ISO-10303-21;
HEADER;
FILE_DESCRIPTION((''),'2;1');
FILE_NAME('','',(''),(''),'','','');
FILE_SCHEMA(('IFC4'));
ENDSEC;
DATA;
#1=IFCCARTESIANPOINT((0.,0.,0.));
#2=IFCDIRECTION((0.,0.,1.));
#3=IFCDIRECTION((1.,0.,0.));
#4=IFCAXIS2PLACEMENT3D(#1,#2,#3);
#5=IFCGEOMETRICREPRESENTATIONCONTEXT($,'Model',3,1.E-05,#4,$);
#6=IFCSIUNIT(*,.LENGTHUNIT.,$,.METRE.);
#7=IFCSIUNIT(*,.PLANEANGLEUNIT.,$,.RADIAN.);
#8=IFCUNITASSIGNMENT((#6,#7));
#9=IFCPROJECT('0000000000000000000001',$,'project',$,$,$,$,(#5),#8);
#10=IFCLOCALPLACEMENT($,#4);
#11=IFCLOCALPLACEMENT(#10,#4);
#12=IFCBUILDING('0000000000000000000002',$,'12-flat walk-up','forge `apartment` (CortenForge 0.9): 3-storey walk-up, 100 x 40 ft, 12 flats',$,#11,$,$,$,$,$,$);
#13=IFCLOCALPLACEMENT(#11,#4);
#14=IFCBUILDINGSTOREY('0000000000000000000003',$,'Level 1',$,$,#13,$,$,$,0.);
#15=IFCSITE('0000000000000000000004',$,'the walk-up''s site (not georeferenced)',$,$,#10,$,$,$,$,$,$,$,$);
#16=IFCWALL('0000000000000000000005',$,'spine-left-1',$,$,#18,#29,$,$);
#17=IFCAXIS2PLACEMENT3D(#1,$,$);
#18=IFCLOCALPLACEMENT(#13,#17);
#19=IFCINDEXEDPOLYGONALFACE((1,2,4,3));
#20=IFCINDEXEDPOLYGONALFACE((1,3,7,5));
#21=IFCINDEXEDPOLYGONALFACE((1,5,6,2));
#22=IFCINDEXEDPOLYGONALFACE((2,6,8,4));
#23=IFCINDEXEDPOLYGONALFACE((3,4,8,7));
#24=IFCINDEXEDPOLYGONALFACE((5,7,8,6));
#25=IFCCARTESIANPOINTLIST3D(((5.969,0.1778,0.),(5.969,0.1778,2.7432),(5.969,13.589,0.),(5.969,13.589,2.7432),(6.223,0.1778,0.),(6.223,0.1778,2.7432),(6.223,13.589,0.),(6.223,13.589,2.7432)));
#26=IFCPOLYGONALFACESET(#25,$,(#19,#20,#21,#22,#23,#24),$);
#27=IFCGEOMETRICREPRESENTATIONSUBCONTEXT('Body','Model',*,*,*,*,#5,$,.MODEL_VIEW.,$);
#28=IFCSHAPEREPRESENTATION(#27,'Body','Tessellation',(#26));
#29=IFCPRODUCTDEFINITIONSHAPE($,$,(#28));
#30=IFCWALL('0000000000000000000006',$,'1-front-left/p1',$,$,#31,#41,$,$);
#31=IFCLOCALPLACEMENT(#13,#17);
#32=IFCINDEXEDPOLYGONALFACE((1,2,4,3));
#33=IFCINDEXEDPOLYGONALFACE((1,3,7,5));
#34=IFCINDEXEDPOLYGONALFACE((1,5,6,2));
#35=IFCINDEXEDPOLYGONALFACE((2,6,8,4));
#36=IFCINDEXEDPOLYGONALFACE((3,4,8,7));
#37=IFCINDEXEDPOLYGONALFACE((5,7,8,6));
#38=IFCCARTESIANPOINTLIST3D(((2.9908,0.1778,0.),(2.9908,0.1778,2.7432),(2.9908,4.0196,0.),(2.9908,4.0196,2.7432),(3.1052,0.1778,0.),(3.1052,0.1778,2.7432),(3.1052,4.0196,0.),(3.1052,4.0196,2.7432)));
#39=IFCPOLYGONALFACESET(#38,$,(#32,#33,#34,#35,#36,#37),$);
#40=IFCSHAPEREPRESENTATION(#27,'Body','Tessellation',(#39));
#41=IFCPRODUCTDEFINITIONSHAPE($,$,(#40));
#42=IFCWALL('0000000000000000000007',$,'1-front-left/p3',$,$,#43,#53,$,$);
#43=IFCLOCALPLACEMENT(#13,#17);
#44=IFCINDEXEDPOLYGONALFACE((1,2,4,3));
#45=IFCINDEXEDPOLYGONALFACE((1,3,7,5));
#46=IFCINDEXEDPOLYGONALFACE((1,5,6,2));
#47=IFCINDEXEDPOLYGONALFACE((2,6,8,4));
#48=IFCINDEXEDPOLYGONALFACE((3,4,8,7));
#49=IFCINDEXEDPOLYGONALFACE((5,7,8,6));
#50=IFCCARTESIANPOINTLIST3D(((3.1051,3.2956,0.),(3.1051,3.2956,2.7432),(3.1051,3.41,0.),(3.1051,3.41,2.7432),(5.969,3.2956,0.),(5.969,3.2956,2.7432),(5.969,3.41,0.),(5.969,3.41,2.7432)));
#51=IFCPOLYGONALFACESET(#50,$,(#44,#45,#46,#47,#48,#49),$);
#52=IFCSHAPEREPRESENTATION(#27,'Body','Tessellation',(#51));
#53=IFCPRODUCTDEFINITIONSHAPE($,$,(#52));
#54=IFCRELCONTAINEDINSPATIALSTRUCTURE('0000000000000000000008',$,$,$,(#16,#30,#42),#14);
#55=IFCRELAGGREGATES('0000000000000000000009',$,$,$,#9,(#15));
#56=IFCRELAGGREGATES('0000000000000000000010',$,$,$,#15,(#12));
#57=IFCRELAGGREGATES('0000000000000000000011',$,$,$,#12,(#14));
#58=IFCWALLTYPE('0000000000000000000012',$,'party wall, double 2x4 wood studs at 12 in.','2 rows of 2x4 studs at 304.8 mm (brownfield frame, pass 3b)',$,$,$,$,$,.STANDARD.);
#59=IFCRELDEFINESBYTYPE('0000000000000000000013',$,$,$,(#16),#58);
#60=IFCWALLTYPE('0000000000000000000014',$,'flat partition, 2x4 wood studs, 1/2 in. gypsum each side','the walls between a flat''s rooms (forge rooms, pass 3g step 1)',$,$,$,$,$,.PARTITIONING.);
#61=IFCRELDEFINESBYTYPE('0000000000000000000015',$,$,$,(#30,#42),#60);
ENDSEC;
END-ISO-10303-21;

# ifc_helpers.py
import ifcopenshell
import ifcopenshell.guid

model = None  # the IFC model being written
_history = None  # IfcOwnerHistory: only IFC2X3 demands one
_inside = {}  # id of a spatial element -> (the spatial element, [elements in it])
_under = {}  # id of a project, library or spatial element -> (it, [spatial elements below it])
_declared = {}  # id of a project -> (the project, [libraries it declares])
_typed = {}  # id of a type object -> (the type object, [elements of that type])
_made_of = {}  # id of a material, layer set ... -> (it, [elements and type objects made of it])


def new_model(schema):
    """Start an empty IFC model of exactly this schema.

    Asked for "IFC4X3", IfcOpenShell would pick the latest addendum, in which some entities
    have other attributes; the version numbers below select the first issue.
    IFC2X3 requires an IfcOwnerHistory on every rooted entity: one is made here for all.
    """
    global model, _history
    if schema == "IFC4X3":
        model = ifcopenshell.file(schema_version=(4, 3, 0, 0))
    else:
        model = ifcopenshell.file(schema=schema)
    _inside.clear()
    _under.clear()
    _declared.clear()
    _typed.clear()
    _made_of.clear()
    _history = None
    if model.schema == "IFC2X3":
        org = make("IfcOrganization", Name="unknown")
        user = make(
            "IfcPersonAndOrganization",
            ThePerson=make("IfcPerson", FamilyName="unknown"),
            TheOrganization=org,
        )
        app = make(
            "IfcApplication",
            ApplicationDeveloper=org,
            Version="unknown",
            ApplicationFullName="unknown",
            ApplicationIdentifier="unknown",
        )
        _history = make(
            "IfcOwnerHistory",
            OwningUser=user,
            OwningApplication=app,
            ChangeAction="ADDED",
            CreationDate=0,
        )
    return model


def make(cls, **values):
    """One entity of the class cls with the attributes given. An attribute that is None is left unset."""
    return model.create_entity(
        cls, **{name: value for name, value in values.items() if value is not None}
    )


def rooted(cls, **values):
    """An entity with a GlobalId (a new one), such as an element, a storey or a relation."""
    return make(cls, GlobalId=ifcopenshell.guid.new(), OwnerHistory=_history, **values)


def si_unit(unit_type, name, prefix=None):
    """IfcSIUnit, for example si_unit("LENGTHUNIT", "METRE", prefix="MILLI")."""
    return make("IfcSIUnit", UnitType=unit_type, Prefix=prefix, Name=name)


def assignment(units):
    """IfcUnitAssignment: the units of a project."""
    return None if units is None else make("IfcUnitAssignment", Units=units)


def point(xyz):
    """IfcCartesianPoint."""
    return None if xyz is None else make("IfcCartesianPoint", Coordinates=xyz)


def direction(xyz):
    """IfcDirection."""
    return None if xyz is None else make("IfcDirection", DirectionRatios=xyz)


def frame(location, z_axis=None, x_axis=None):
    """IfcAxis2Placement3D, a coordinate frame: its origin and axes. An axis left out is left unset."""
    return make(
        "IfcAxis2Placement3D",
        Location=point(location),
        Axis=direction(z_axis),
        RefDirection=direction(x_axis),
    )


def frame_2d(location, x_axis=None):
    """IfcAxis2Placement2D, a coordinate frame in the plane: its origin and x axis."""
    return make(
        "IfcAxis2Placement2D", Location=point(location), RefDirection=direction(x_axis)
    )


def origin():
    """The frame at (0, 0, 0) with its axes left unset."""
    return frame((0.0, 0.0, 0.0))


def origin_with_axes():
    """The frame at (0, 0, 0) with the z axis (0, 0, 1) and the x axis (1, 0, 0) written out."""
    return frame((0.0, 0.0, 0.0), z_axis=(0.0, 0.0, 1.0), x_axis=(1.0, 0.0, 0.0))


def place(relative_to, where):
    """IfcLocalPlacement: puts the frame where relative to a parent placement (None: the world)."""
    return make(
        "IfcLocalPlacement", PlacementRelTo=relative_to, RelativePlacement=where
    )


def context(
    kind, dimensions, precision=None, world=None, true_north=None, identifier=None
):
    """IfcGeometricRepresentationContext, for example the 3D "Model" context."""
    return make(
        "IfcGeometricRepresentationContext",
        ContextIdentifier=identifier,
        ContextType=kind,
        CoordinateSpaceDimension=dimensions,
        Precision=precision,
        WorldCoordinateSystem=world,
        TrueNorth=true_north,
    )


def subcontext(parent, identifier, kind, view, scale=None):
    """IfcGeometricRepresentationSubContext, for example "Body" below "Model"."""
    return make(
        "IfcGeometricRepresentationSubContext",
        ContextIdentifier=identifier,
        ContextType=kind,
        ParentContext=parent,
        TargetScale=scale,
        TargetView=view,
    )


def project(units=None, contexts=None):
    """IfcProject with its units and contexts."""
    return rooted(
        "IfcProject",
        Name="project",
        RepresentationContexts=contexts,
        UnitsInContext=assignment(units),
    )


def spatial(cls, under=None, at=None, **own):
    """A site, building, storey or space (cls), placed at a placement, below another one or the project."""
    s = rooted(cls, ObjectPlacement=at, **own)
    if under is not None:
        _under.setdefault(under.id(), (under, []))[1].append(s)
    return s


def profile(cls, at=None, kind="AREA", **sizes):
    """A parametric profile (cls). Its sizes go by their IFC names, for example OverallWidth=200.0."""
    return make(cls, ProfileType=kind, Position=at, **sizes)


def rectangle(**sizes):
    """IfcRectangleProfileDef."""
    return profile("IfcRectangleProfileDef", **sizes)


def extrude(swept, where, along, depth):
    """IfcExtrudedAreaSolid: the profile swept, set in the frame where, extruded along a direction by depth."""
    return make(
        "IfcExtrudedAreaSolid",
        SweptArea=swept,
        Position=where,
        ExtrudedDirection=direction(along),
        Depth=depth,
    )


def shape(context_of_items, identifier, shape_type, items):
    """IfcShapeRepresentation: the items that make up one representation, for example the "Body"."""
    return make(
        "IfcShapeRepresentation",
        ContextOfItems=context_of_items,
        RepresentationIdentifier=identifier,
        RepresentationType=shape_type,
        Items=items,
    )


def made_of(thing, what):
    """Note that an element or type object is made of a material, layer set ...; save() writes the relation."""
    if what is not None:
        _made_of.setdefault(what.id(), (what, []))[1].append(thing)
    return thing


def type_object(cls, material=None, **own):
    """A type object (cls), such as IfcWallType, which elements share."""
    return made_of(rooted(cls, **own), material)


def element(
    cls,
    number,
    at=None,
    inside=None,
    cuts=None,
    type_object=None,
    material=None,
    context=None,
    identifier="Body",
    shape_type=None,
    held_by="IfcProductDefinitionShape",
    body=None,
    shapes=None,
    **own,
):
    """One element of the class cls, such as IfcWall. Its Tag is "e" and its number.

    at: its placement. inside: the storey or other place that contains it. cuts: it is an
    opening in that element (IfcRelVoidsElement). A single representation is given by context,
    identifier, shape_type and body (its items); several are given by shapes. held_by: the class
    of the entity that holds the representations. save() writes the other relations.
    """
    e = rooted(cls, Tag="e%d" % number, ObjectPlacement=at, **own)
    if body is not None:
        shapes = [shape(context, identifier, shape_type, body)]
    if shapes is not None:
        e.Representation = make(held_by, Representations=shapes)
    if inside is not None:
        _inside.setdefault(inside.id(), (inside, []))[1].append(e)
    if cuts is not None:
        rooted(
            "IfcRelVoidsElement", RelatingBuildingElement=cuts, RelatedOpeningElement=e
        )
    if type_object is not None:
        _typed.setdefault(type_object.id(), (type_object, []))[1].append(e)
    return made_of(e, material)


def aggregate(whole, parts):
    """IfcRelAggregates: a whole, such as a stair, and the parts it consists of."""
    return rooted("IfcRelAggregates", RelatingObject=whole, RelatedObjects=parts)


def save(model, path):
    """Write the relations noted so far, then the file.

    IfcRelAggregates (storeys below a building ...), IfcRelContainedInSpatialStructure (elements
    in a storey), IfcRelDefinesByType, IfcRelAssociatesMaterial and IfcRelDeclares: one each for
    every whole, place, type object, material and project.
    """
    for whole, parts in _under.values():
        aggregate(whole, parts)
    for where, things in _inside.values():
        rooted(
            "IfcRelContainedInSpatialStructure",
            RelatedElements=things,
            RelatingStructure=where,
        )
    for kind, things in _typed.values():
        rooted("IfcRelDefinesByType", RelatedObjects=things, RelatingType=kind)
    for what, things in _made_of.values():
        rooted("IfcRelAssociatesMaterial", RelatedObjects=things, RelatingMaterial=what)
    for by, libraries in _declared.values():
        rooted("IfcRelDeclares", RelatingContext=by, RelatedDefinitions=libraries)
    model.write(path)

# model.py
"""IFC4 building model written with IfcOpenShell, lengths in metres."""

from ifc_helpers import new_model, si_unit, frame, frame_2d, origin, origin_with_axes, place, context, subcontext, project, spatial, rectangle, extrude, type_object, element, save


model = new_model("IFC4")

# Units and contexts
model_context = context("Model", 3, precision=1e-05, world=origin_with_axes())
body_context = subcontext(model_context, "Body", "Model", "MODEL_VIEW")
ifc_project = project(units=[si_unit("LENGTHUNIT", "METRE"), si_unit("PLANEANGLEUNIT", "RADIAN")], contexts=[model_context])

# Site, building, storey
site_placement = place(None, origin_with_axes())
site = spatial("IfcSite", under=ifc_project, at=site_placement, Name="the walk-up's site (not georeferenced)")
building_placement = place(site_placement, origin_with_axes())
building = spatial("IfcBuilding", under=site, at=building_placement, Name="12-flat walk-up", Description="forge `apartment` (CortenForge 0.9): 3-storey walk-up, 100 x 40 ft, 12 flats")
storey_placement = place(building_placement, origin_with_axes())
storey = spatial("IfcBuildingStorey", under=building, at=storey_placement, Name="Level 1", Elevation=0.0)

# Walls
wall_type_1 = type_object("IfcWallType", Name="party wall, double 2x4 wood studs at 12 in.", Description="2 rows of 2x4 studs at 304.8 mm (brownfield frame, pass 3b)", PredefinedType="STANDARD")
wall_1_placement = place(storey_placement, frame((5.969, 0.1778, 0.0), z_axis=(0.0, 0.0, 1.0), x_axis=(1.0, 0.0, 0.0)))
element("IfcWall", 1, at=wall_1_placement, inside=storey, type_object=wall_type_1, Name="spine-left-1", context=body_context, shape_type="SweptSolid", body=[
    extrude(rectangle(XDim=0.254, YDim=13.4112, at=frame_2d((0.127, 6.7056))), origin(), (0.0, 0.0, 1.0), 2.7432),
])
wall_type_2 = type_object("IfcWallType", Name="flat partition, 2x4 wood studs, 1/2 in. gypsum each side", Description="the walls between a flat's rooms (forge rooms, pass 3g step 1)", PredefinedType="PARTITIONING")
wall_2_placement = place(storey_placement, frame((2.9909, 0.1778, 0.0), z_axis=(0.0, 0.0, 1.0), x_axis=(1.0, 0.0, 0.0)))
element("IfcWall", 2, at=wall_2_placement, inside=storey, type_object=wall_type_2, Name="1-front-left/p1", context=body_context, shape_type="SweptSolid", body=[
    extrude(rectangle(XDim=0.1143, YDim=3.8417, at=frame_2d((0.0572, 1.9209))), origin(), (0.0, 0.0, 1.0), 2.7432),
])
wall_3_placement = place(storey_placement, frame((3.1051, 3.2957, 0.0), z_axis=(0.0, 0.0, 1.0), x_axis=(1.0, 0.0, 0.0)))
element("IfcWall", 3, at=wall_3_placement, inside=storey, type_object=wall_type_2, Name="1-front-left/p3", context=body_context, shape_type="SweptSolid", body=[
    extrude(rectangle(XDim=2.8639, YDim=0.1143, at=frame_2d((1.4319, 0.0571))), origin(), (0.0, 0.0, 1.0), 2.7432),
])

save(model, "model.ifc")
